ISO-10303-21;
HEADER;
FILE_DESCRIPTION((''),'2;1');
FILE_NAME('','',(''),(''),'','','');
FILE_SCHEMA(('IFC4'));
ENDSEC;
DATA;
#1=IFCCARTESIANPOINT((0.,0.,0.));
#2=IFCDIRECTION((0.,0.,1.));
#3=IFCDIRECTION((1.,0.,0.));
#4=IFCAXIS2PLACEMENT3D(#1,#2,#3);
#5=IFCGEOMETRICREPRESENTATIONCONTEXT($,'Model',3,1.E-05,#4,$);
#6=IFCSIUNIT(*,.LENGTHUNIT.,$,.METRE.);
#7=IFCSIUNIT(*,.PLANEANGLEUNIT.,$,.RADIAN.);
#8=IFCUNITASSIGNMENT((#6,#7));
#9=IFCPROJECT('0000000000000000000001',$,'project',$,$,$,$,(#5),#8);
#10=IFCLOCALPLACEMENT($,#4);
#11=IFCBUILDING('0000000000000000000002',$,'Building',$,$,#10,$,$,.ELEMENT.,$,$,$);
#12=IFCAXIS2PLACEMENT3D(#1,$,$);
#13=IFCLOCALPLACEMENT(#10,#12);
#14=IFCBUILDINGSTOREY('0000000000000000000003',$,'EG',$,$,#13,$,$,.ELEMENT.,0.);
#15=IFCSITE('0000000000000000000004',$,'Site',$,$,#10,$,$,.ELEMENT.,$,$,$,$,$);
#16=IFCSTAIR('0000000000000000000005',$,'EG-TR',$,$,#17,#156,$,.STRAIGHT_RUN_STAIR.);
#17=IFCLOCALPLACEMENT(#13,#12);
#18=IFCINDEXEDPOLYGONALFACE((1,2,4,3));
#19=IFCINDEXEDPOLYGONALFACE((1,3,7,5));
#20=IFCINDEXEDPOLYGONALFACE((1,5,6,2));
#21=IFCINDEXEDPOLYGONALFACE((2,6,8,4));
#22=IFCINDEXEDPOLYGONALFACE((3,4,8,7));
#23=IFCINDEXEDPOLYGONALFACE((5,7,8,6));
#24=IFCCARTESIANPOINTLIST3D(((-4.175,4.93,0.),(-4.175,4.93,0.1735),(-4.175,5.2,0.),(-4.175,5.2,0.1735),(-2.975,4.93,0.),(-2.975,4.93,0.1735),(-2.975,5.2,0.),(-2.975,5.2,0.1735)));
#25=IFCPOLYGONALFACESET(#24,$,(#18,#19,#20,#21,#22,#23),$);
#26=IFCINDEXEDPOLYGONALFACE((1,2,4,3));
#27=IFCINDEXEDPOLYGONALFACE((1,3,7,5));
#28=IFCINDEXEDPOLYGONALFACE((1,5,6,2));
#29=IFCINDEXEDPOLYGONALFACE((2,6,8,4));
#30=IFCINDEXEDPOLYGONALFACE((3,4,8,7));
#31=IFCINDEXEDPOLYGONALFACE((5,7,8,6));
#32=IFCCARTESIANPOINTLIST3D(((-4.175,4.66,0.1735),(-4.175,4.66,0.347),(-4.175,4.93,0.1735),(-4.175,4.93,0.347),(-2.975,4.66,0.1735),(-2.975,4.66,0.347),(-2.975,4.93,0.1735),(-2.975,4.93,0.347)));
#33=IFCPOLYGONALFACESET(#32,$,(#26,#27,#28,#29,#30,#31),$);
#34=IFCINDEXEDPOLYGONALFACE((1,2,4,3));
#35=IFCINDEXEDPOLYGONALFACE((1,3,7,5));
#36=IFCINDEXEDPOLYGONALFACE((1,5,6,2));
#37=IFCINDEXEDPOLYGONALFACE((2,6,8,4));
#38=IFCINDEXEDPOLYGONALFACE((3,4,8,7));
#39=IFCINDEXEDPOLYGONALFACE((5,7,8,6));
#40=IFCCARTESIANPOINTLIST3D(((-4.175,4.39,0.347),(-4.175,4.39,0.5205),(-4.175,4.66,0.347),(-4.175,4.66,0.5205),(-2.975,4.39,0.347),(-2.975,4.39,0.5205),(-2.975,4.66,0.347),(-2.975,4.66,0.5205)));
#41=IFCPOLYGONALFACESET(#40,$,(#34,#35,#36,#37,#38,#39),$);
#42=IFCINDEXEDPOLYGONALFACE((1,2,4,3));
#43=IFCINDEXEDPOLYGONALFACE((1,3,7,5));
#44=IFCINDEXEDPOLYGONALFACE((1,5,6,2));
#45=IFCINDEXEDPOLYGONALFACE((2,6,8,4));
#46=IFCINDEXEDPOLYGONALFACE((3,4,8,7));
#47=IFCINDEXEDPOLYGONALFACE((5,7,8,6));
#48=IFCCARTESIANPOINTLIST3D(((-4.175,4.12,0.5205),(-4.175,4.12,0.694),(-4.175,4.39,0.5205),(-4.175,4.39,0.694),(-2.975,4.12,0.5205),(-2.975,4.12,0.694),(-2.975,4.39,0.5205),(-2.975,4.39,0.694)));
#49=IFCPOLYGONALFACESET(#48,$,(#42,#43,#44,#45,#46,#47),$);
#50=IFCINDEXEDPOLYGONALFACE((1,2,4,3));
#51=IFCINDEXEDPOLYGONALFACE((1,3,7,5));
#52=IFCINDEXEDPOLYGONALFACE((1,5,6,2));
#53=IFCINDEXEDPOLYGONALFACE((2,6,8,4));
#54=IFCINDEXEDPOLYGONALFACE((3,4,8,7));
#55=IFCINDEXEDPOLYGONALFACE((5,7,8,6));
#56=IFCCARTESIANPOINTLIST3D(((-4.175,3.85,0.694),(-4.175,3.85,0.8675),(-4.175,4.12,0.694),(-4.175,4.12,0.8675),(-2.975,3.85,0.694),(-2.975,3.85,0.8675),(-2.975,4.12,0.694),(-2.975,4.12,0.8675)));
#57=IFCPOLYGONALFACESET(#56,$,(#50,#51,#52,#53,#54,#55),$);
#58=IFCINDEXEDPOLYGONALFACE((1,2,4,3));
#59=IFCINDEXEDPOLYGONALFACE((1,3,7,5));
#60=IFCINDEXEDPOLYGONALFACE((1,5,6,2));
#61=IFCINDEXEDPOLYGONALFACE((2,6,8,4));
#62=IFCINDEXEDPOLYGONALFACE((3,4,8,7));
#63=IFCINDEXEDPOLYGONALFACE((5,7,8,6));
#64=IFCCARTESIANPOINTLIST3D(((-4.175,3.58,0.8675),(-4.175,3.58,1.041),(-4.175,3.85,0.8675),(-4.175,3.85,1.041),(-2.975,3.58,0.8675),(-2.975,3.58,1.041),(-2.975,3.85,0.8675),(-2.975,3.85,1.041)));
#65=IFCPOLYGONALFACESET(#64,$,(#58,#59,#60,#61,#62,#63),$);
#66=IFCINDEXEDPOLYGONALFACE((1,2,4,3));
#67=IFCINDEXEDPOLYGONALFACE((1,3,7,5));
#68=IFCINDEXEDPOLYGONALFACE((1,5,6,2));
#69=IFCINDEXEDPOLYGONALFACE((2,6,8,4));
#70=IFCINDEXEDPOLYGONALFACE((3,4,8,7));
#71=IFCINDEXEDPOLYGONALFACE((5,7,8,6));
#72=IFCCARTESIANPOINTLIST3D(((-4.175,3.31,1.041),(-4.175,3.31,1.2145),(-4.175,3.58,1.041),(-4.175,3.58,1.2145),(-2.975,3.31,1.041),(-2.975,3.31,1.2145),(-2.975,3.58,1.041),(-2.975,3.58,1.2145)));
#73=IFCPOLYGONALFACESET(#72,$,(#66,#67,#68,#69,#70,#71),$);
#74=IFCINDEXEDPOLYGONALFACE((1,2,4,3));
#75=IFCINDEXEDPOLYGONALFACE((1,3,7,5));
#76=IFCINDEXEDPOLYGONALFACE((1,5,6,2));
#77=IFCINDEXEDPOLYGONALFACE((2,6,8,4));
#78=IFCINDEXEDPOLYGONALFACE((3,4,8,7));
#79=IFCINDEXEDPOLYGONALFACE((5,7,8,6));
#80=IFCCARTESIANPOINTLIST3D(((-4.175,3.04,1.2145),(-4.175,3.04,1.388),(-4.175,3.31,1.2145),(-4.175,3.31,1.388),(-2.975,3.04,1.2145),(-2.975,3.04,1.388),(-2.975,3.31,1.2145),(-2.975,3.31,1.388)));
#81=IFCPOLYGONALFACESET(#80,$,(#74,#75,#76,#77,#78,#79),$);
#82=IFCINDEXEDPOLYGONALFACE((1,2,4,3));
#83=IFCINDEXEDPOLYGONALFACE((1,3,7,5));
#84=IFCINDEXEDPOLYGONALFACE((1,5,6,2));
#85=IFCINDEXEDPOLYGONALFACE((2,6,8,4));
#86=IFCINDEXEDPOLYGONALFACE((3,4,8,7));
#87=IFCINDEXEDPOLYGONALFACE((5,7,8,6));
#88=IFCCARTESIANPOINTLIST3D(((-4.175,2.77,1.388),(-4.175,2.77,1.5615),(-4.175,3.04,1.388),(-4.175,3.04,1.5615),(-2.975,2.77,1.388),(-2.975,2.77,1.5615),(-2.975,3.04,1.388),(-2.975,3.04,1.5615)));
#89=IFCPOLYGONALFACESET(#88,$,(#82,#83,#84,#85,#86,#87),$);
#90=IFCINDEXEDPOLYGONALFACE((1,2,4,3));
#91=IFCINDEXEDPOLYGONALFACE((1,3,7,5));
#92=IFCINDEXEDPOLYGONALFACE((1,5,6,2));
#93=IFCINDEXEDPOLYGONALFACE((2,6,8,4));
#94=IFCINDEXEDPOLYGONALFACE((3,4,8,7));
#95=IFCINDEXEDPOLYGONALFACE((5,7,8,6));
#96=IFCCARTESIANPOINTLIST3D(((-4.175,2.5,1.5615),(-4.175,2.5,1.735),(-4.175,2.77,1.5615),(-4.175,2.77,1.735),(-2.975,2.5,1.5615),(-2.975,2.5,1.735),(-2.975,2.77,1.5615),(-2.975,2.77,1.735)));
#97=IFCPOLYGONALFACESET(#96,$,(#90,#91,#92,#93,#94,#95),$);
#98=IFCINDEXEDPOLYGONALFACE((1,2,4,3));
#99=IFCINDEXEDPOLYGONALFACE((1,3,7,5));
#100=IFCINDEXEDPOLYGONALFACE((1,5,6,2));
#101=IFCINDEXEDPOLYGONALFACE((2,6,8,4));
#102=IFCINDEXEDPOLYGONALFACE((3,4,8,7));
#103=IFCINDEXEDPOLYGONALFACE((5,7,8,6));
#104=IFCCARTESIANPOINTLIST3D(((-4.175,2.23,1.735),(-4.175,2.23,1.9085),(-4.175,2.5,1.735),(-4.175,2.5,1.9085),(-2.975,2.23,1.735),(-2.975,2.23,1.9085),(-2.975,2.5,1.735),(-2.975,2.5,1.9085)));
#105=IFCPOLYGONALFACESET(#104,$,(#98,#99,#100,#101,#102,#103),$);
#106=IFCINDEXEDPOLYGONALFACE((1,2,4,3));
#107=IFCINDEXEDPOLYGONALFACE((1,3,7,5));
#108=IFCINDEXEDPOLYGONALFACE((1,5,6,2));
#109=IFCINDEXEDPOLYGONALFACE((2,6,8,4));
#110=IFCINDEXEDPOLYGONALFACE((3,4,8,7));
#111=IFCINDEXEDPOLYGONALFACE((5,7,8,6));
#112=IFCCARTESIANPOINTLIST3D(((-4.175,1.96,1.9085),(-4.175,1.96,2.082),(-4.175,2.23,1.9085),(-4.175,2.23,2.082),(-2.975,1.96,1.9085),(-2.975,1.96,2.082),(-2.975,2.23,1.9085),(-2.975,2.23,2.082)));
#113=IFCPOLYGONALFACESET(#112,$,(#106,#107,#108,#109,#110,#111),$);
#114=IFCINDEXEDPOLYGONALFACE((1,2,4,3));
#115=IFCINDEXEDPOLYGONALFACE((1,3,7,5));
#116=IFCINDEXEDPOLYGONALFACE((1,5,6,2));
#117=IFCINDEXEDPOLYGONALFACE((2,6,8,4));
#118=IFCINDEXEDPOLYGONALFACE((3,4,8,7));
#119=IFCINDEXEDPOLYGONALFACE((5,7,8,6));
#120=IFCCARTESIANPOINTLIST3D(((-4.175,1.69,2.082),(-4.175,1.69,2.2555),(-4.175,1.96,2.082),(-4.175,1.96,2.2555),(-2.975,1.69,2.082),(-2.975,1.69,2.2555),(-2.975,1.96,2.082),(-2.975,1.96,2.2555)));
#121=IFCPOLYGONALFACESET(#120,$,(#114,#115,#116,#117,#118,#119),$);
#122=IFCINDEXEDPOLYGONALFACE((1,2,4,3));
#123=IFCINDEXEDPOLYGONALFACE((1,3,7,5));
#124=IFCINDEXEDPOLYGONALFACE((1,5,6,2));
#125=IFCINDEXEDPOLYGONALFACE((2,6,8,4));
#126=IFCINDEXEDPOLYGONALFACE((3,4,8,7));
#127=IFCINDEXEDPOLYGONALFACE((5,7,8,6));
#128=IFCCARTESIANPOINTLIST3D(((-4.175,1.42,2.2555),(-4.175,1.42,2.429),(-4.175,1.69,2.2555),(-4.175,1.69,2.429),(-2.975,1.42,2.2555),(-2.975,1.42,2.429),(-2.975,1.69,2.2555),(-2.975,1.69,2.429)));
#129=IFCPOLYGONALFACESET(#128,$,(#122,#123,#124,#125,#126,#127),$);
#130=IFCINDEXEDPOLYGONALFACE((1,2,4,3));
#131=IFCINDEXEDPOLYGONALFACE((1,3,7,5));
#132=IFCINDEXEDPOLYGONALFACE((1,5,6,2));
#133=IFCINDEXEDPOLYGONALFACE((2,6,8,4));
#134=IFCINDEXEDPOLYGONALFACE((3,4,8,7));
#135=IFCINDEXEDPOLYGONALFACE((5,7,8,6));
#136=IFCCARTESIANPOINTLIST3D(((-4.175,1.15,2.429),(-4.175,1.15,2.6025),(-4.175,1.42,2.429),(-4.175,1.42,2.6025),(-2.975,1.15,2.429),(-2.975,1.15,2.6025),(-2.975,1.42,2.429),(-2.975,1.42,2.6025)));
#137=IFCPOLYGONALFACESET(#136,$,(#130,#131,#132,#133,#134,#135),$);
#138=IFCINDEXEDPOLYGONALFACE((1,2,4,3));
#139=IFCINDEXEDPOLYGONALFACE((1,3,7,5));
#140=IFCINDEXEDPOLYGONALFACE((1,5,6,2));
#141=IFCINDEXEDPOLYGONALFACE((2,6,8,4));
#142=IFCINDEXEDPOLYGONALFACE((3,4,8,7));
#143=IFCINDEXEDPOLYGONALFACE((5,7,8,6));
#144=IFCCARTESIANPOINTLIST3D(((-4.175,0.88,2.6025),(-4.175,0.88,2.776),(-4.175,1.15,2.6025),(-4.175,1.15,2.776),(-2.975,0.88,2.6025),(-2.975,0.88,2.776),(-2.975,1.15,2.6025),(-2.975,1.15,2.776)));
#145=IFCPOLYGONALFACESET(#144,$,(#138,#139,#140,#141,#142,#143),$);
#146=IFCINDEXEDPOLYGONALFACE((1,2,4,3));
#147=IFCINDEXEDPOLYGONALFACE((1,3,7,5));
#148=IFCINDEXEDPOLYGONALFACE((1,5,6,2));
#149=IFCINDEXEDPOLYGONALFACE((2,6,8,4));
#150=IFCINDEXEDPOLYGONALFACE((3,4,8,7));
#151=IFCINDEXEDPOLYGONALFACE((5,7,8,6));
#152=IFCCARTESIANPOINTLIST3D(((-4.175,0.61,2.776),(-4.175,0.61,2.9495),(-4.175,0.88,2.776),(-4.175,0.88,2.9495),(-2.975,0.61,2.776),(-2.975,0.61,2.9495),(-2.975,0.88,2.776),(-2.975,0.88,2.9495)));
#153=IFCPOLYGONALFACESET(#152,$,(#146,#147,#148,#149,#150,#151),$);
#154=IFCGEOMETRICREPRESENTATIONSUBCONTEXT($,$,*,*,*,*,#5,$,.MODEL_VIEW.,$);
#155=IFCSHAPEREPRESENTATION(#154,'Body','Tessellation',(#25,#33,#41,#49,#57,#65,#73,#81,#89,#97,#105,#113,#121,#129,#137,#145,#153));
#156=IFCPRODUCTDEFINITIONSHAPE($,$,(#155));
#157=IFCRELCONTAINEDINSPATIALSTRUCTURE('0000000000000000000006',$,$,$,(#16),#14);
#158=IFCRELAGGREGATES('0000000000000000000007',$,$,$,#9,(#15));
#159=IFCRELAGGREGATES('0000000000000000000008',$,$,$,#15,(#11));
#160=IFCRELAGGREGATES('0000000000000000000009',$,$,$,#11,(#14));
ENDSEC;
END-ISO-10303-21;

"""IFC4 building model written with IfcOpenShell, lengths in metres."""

from ifc_helpers import new_model, si_unit, frame, frame_2d, origin, origin_with_axes, place, context, subcontext, project, spatial, rectangle, extrude, element, save


model = new_model("IFC4")

# Units and contexts
model_context = context("Model", 3, precision=1e-05, world=origin_with_axes())
sub_context = subcontext(model_context, None, None, "MODEL_VIEW")
ifc_project = project(units=[si_unit("LENGTHUNIT", "METRE"), si_unit("PLANEANGLEUNIT", "RADIAN")], contexts=[model_context])

# Site, building, storey
placement = place(None, origin_with_axes())
site = spatial("IfcSite", under=ifc_project, at=placement, Name="Site", CompositionType="ELEMENT")
building = spatial("IfcBuilding", under=site, at=placement, Name="Building", CompositionType="ELEMENT")
storey_placement = place(placement, origin())
storey = spatial("IfcBuildingStorey", under=building, at=storey_placement, Name="EG", CompositionType="ELEMENT", Elevation=0.0)

# Stair
stair_placement = place(storey_placement, frame((-4.175, 5.2, 0.0), z_axis=(0.0, 0.0, 1.0), x_axis=(0.0, -1.0, 0.0)))
element("IfcStair", 1, at=stair_placement, inside=storey, Name="EG-TR", PredefinedType="STRAIGHT_RUN_STAIR", context=sub_context, shape_type="SolidModel", body=[
    extrude(rectangle(XDim=0.27, YDim=1.2, at=frame_2d((0.135, 0.6))), origin(), (0.0, 0.0, 1.0), 0.1735),
    extrude(rectangle(XDim=0.27, YDim=1.2, at=frame_2d((0.135, 0.6))), frame((0.27, 0.0, 0.1735)), (0.0, 0.0, 1.0), 0.1735),
    extrude(rectangle(XDim=0.27, YDim=1.2, at=frame_2d((0.135, 0.6))), frame((0.54, 0.0, 0.347)), (0.0, 0.0, 1.0), 0.1735),
    extrude(rectangle(XDim=0.27, YDim=1.2, at=frame_2d((0.135, 0.6))), frame((0.81, 0.0, 0.5205)), (0.0, 0.0, 1.0), 0.1735),
    extrude(rectangle(XDim=0.27, YDim=1.2, at=frame_2d((0.135, 0.6))), frame((1.08, 0.0, 0.694)), (0.0, 0.0, 1.0), 0.1735),
    extrude(rectangle(XDim=0.27, YDim=1.2, at=frame_2d((0.135, 0.6))), frame((1.35, 0.0, 0.8675)), (0.0, 0.0, 1.0), 0.1735),
    extrude(rectangle(XDim=0.27, YDim=1.2, at=frame_2d((0.135, 0.6))), frame((1.62, 0.0, 1.041)), (0.0, 0.0, 1.0), 0.1735),
    extrude(rectangle(XDim=0.27, YDim=1.2, at=frame_2d((0.135, 0.6))), frame((1.89, 0.0, 1.2145)), (0.0, 0.0, 1.0), 0.1735),
    extrude(rectangle(XDim=0.27, YDim=1.2, at=frame_2d((0.135, 0.6))), frame((2.16, 0.0, 1.388)), (0.0, 0.0, 1.0), 0.1735),
    extrude(rectangle(XDim=0.27, YDim=1.2, at=frame_2d((0.135, 0.6))), frame((2.43, 0.0, 1.5615)), (0.0, 0.0, 1.0), 0.1735),
    extrude(rectangle(XDim=0.27, YDim=1.2, at=frame_2d((0.135, 0.6))), frame((2.7, 0.0, 1.735)), (0.0, 0.0, 1.0), 0.1735),
    extrude(rectangle(XDim=0.27, YDim=1.2, at=frame_2d((0.135, 0.6))), frame((2.97, 0.0, 1.9085)), (0.0, 0.0, 1.0), 0.1735),
    extrude(rectangle(XDim=0.27, YDim=1.2, at=frame_2d((0.135, 0.6))), frame((3.24, 0.0, 2.082)), (0.0, 0.0, 1.0), 0.1735),
    extrude(rectangle(XDim=0.27, YDim=1.2, at=frame_2d((0.135, 0.6))), frame((3.51, 0.0, 2.2555)), (0.0, 0.0, 1.0), 0.1735),
    extrude(rectangle(XDim=0.27, YDim=1.2, at=frame_2d((0.135, 0.6))), frame((3.78, 0.0, 2.429)), (0.0, 0.0, 1.0), 0.1735),
    extrude(rectangle(XDim=0.27, YDim=1.2, at=frame_2d((0.135, 0.6))), frame((4.05, 0.0, 2.6025)), (0.0, 0.0, 1.0), 0.1735),
    extrude(rectangle(XDim=0.27, YDim=1.2, at=frame_2d((0.135, 0.6))), frame((4.32, 0.0, 2.776)), (0.0, 0.0, 1.0), 0.1735),
])

save(model, "model.ifc")
